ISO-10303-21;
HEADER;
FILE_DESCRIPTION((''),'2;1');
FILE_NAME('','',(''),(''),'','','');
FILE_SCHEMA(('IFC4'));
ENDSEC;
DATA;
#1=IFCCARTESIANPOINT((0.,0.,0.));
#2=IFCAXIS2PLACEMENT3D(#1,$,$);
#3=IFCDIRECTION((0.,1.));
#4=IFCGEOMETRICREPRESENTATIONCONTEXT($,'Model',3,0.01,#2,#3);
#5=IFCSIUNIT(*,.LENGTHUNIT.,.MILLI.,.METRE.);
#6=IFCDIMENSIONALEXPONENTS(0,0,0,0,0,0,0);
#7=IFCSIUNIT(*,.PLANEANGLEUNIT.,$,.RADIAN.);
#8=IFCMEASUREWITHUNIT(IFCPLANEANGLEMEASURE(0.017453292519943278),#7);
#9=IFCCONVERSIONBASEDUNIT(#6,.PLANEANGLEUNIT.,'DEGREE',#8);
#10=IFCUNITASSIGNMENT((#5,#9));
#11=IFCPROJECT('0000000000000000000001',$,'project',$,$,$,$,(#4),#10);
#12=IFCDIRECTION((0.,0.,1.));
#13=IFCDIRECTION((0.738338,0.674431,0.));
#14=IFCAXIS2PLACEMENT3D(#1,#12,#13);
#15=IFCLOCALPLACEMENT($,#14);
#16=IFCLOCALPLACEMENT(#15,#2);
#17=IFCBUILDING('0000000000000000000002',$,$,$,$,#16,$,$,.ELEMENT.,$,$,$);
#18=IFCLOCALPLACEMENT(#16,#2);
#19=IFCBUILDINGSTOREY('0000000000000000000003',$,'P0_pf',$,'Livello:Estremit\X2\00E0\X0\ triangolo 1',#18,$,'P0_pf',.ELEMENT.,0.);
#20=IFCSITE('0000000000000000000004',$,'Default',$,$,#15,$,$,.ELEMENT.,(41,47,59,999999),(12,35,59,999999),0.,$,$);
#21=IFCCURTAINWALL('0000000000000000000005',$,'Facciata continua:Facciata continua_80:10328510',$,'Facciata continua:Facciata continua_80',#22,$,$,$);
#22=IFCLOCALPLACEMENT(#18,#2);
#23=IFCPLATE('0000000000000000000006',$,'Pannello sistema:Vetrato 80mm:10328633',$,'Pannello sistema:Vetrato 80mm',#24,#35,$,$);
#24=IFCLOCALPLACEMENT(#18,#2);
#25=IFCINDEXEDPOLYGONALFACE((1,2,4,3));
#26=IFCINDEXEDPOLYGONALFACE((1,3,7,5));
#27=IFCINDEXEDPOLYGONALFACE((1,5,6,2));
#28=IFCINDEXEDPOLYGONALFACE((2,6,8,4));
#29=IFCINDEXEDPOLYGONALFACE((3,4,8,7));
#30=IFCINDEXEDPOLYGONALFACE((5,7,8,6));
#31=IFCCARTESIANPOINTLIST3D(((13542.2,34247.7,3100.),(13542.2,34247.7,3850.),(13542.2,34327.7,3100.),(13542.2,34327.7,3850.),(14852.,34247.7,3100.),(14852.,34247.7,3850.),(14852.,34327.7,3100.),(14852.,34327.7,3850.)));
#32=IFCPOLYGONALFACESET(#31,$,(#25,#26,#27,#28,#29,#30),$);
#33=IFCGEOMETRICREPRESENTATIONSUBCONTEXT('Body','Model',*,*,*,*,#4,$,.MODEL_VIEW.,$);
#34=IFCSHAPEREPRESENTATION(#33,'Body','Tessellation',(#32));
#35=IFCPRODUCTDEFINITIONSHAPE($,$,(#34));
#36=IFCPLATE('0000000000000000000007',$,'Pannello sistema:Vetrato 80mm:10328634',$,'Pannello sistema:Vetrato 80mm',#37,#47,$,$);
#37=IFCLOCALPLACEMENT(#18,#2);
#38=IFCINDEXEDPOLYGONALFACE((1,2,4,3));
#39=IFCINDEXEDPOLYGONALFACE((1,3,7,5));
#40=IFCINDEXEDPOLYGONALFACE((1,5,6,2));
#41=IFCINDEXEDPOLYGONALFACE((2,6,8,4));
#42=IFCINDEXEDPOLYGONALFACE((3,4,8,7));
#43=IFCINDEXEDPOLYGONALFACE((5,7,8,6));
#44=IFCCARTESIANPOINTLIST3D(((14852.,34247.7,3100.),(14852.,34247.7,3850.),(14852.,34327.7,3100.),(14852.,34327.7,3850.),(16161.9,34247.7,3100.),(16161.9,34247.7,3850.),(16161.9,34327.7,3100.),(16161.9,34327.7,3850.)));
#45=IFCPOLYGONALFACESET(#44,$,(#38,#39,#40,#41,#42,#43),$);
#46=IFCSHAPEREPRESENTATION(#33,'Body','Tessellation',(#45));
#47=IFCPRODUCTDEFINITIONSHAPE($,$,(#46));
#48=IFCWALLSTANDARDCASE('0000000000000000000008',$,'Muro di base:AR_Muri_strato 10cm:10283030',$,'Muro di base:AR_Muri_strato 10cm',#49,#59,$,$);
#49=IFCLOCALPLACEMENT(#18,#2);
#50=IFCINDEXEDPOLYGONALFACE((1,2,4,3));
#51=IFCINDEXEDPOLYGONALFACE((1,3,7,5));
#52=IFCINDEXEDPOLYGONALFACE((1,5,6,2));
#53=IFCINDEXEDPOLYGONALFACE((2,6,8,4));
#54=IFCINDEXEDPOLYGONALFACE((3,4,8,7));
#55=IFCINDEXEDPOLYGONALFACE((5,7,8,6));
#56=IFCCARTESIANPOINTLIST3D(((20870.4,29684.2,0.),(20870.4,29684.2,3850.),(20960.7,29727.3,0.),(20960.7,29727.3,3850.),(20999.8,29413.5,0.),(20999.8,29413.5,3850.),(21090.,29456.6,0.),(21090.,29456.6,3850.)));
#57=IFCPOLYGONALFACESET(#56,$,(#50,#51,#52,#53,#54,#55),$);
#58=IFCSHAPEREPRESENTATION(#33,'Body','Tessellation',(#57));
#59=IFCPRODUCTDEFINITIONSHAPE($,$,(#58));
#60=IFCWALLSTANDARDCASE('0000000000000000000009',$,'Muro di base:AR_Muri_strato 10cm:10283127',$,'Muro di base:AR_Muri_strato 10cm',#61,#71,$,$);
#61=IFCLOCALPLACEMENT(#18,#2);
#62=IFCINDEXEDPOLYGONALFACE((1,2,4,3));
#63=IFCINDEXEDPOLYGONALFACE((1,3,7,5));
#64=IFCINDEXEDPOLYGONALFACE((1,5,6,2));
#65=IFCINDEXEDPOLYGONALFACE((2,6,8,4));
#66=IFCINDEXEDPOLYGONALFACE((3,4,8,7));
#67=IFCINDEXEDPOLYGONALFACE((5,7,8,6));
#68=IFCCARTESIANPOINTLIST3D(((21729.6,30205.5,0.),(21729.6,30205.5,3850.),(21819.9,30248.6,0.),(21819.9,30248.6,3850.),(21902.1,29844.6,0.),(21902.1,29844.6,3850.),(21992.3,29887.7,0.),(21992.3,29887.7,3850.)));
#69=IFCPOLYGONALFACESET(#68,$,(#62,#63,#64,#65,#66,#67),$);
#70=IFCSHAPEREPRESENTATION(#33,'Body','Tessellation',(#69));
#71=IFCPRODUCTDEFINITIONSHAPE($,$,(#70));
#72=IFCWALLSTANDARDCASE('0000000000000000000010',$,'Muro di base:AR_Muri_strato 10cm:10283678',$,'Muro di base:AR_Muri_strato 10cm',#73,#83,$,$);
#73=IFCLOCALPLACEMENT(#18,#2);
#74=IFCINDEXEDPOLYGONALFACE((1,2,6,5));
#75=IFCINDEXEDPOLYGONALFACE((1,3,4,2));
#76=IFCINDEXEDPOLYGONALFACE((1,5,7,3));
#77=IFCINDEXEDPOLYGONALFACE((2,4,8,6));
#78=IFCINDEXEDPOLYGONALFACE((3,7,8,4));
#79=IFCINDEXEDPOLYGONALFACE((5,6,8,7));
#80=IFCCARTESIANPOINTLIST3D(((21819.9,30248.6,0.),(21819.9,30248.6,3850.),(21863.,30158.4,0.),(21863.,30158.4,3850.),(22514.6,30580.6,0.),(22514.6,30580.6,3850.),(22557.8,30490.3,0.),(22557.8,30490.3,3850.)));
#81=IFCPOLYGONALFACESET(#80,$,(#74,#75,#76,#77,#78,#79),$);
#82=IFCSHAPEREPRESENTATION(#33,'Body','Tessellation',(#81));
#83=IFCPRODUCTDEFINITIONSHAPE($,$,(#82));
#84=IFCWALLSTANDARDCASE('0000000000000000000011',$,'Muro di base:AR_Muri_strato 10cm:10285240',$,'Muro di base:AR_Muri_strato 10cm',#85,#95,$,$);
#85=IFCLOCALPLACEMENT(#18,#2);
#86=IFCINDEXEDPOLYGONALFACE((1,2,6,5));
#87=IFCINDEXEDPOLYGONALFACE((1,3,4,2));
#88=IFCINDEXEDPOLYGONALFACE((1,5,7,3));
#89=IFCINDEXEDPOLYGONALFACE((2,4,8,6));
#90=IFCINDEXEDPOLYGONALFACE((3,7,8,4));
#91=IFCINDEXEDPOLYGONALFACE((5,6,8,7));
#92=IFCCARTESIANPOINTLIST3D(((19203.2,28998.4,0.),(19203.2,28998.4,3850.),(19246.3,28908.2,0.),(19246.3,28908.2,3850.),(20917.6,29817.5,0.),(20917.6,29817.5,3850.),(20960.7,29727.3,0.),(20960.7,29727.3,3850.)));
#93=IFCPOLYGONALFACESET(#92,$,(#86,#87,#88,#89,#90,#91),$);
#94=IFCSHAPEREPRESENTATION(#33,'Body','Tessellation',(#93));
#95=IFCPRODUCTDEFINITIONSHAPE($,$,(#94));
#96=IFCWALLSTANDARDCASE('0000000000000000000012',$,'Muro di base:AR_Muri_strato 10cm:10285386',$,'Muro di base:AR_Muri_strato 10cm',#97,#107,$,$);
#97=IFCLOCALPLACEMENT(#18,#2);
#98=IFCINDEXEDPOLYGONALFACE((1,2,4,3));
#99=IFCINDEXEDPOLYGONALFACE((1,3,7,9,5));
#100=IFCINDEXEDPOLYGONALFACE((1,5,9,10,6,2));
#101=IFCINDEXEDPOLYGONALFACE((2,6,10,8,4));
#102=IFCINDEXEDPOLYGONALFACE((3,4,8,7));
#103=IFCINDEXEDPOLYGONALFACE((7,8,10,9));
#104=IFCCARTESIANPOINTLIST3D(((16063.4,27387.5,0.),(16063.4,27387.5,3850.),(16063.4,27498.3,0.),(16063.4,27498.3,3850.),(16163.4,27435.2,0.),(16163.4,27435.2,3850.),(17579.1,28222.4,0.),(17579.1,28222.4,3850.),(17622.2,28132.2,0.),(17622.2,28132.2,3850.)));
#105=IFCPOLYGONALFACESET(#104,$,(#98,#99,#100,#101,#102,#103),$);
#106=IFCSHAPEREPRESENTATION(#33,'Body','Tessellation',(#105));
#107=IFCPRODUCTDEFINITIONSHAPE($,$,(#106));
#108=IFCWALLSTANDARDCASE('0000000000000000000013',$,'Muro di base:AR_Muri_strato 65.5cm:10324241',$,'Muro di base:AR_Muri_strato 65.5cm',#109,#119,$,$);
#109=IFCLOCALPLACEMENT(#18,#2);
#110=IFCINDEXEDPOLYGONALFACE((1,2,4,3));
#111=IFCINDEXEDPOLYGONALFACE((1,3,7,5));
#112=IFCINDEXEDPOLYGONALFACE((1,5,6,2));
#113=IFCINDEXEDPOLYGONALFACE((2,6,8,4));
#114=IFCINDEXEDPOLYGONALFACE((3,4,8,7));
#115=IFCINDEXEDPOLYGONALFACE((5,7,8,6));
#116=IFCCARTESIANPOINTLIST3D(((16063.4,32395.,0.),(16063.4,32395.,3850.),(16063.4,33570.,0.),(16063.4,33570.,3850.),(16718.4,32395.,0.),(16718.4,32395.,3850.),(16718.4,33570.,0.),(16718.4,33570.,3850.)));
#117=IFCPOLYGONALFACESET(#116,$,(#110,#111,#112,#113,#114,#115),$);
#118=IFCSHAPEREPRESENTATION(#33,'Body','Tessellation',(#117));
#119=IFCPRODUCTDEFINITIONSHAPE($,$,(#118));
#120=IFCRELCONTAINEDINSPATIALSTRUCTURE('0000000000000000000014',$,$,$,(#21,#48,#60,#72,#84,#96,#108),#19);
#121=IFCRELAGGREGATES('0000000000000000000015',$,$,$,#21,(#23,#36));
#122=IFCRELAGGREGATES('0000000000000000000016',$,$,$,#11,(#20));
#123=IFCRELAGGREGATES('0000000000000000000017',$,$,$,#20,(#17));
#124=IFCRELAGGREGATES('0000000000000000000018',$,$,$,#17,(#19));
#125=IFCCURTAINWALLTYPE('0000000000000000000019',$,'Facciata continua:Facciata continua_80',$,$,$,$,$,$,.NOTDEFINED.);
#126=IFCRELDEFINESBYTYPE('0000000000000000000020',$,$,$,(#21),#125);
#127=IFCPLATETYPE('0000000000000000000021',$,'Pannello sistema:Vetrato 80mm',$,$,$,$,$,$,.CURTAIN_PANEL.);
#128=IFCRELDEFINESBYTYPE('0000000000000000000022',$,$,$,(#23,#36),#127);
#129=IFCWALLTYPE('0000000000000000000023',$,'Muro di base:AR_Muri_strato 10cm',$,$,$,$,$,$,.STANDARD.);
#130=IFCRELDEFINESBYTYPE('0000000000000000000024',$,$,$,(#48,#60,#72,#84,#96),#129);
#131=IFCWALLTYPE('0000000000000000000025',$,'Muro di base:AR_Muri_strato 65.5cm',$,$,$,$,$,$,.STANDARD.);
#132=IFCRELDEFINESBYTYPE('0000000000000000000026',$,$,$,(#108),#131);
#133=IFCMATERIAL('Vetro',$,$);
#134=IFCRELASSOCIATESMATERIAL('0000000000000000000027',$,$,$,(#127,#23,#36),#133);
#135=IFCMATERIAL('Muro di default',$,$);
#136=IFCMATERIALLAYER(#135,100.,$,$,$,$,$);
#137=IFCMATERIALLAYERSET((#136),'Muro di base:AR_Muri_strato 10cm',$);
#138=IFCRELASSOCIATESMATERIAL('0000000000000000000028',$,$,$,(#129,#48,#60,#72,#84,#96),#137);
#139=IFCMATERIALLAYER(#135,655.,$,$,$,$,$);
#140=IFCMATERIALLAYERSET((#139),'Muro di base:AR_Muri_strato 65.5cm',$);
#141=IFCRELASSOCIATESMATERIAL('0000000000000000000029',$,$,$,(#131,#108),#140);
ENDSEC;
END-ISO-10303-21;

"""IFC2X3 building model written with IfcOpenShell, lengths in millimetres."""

from ifc_helpers import new_model, entity, si_unit, converted_unit, direction, frame, frame_2d, origin, origin_2d_with_axis, place, context, subcontext, project, spatial, polyline, rectangle, outline, extrude, source, transform, mapped, material, layer, layer_set, layer_usage, type_object, type_shapes, element, aggregate, save


model = new_model("IFC2X3")

# Units and contexts
model_context = context("Model", 3, precision=0.01, world=origin(), true_north=direction((0.0, 1.0)))
body_context = subcontext(model_context, "Body", "Model", "MODEL_VIEW")
ifc_project = project(units=[si_unit("LENGTHUNIT", "METRE", prefix="MILLI"), converted_unit("PLANEANGLEUNIT", "DEGREE", entity("IfcPlaneAngleMeasure", 0.017453292519943278), si_unit("PLANEANGLEUNIT", "RADIAN"), dimensions=[0, 0, 0, 0, 0, 0, 0])], contexts=[model_context])

# Site, building, storey
site_placement = place(None, frame((0.0, 0.0, 0.0), z_axis=(0.0, 0.0, 1.0), x_axis=(0.738338, 0.674431, 0.0)))
site = spatial("IfcSite", under=ifc_project, at=site_placement, Name="Default", CompositionType="ELEMENT", RefLatitude=(41, 47, 59, 999999), RefLongitude=(12, 35, 59, 999999), RefElevation=0.0)
building_placement = place(site_placement, origin())
building = spatial("IfcBuilding", under=site, at=building_placement, CompositionType="ELEMENT")
storey_placement = place(building_placement, origin())
storey = spatial("IfcBuildingStorey", under=building, at=storey_placement, Name="P0_pf", ObjectType="Livello:Estremità triangolo 1", LongName="P0_pf", CompositionType="ELEMENT", Elevation=0.0)

# Curtain wall, plates
curtain_wall_type = type_object("IfcCurtainWallType", Name="Facciata continua:Facciata continua_80", PredefinedType="NOTDEFINED")
ifc_material_1 = material(Name="Vetro")
curtain_wall_1_placement = place(storey_placement, origin())
curtain_wall_1 = element("IfcCurtainWall", 1, at=curtain_wall_1_placement, inside=storey, type_object=curtain_wall_type, Name="Facciata continua:Facciata continua_80:10328510", ObjectType="Facciata continua:Facciata continua_80")
plate_type_1 = type_object("IfcPlateType", Name="Pannello sistema:Vetrato 80mm", PredefinedType="CURTAIN_PANEL", material=ifc_material_1)
shared_shape_1 = source(origin(), body_context, "Body", "SweptSolid", [
    extrude(rectangle(XDim=80.0, YDim=1309.8, at=origin_2d_with_axis()), frame((0.0, -40.0, 0.0), z_axis=(0.0, 0.0, 1.0), x_axis=(0.0, 1.0, 0.0)), (0.0, 0.0, 1.0), 750.0),
])
type_shapes(plate_type_1, [shared_shape_1])
plate_1_placement = place(curtain_wall_1_placement, frame((14197.1, 34327.7, 3100.0)))
plate_1 = element("IfcPlate", 2, at=plate_1_placement, type_object=plate_type_1, material=ifc_material_1, Name="Pannello sistema:Vetrato 80mm:10328633", ObjectType="Pannello sistema:Vetrato 80mm", context=body_context, shape_type="MappedRepresentation", body=[
    mapped(shared_shape_1, transform((0.0, 0.0, 0.0), scale=1.0)),
])
plate_2_placement = place(curtain_wall_1_placement, frame((15506.9, 34327.7, 3100.0)))
plate_2 = element("IfcPlate", 3, at=plate_2_placement, type_object=plate_type_1, material=ifc_material_1, Name="Pannello sistema:Vetrato 80mm:10328634", ObjectType="Pannello sistema:Vetrato 80mm", context=body_context, shape_type="MappedRepresentation", body=[
    mapped(shared_shape_1, transform((0.0, 0.0, 0.0), scale=1.0)),
])
aggregate(curtain_wall_1, [plate_1, plate_2])

# Walls
ifc_material_2 = material(Name="Muro di default")
ifc_layer_1 = layer(ifc_material_2, 100.0)
ifc_layer_set_1 = layer_set([ifc_layer_1], Name="Muro di base:AR_Muri_strato 10cm")
ifc_layer_usage_1 = layer_usage(ifc_layer_set_1, "AXIS2", "NEGATIVE", 50.0)
wall_type_1 = type_object("IfcWallType", Name="Muro di base:AR_Muri_strato 10cm", PredefinedType="STANDARD", material=ifc_layer_set_1)
wall_1_placement = place(storey_placement, frame((21044.9, 29435.0, 0.0), z_axis=(0.0, 0.0, 1.0), x_axis=(-0.431105, 0.902302, 0.0)))
element("IfcWallStandardCase", 4, at=wall_1_placement, inside=storey, type_object=wall_type_1, material=ifc_layer_usage_1, Name="Muro di base:AR_Muri_strato 10cm:10283030", ObjectType="Muro di base:AR_Muri_strato 10cm", context=body_context, shape_type="SweptSolid", body=[
    extrude(rectangle(XDim=300.0, YDim=100.0, at=frame_2d((150.0, 0.0), x_axis=(-1.0, 0.0))), origin(), (0.0, 0.0, 1.0), 3850.0),
])
ifc_layer_usage_2 = layer_usage(ifc_layer_set_1, "AXIS2", "NEGATIVE", 50.0)
wall_2_placement = place(storey_placement, frame((21774.7, 30227.1, 0.0), z_axis=(0.0, 0.0, 1.0), x_axis=(0.431105, -0.902302, 0.0)))
element("IfcWallStandardCase", 5, at=wall_2_placement, inside=storey, type_object=wall_type_1, material=ifc_layer_usage_2, Name="Muro di base:AR_Muri_strato 10cm:10283127", ObjectType="Muro di base:AR_Muri_strato 10cm", context=body_context, shape_type="SweptSolid", body=[
    extrude(rectangle(XDim=400.0, YDim=100.0, at=frame_2d((200.0, 0.0), x_axis=(-1.0, 0.0))), origin(), (0.0, 0.0, 1.0), 3850.0),
])
ifc_layer_usage_3 = layer_usage(ifc_layer_set_1, "AXIS2", "NEGATIVE", 50.0)
wall_3_placement = place(storey_placement, frame((22536.2, 30535.5, 0.0), z_axis=(0.0, 0.0, 1.0), x_axis=(-0.902302, -0.431105, 0.0)))
element("IfcWallStandardCase", 6, at=wall_3_placement, inside=storey, type_object=wall_type_1, material=ifc_layer_usage_3, Name="Muro di base:AR_Muri_strato 10cm:10283678", ObjectType="Muro di base:AR_Muri_strato 10cm", context=body_context, shape_type="SweptSolid", body=[
    extrude(rectangle(XDim=770.0, YDim=100.0, at=frame_2d((385.0, 0.0), x_axis=(-1.0, 0.0))), origin(), (0.0, 0.0, 1.0), 3850.0),
])
ifc_layer_usage_4 = layer_usage(ifc_layer_set_1, "AXIS2", "NEGATIVE", 50.0)
wall_4_placement = place(storey_placement, frame((20939.1, 29772.4, 0.0), z_axis=(0.0, 0.0, 1.0), x_axis=(-0.902302, -0.431105, 0.0)))
element("IfcWallStandardCase", 7, at=wall_4_placement, inside=storey, type_object=wall_type_1, material=ifc_layer_usage_4, Name="Muro di base:AR_Muri_strato 10cm:10285240", ObjectType="Muro di base:AR_Muri_strato 10cm", context=body_context, shape_type="SweptSolid", body=[
    extrude(rectangle(XDim=1900.0, YDim=100.0, at=frame_2d((950.0, 0.0), x_axis=(-1.0, 0.0))), origin(), (0.0, 0.0, 1.0), 3850.0),
])
ifc_layer_usage_5 = layer_usage(ifc_layer_set_1, "AXIS2", "NEGATIVE", 50.0)
wall_5_placement = place(storey_placement, frame((17600.6, 28177.3, 0.0), z_axis=(0.0, 0.0, 1.0), x_axis=(-0.902302, -0.431105, 0.0)))
element("IfcWallStandardCase", 8, at=wall_5_placement, inside=storey, type_object=wall_type_1, material=ifc_layer_usage_5, Name="Muro di base:AR_Muri_strato 10cm:10285386", ObjectType="Muro di base:AR_Muri_strato 10cm", context=body_context, shape_type="SweptSolid", body=[
    extrude(outline(polyline([(1679.7, -50.0), (1727.5, 50.0), (1616.7, 50.0), (0.0, 50.0), (0.0, -50.0), (1679.7, -50.0)])), origin(), (0.0, 0.0, 1.0), 3850.0),
])
ifc_layer_2 = layer(ifc_material_2, 655.0)
ifc_layer_set_2 = layer_set([ifc_layer_2], Name="Muro di base:AR_Muri_strato 65.5cm")
ifc_layer_usage_6 = layer_usage(ifc_layer_set_2, "AXIS2", "NEGATIVE", 327.5)
wall_type_2 = type_object("IfcWallType", Name="Muro di base:AR_Muri_strato 65.5cm", PredefinedType="STANDARD", material=ifc_layer_set_2)
wall_6_placement = place(storey_placement, frame((16390.9, 32395.0, 0.0), z_axis=(0.0, 0.0, 1.0), x_axis=(0.0, 1.0, 0.0)))
element("IfcWallStandardCase", 9, at=wall_6_placement, inside=storey, type_object=wall_type_2, material=ifc_layer_usage_6, Name="Muro di base:AR_Muri_strato 65.5cm:10324241", ObjectType="Muro di base:AR_Muri_strato 65.5cm", context=body_context, shape_type="SweptSolid", body=[
    extrude(rectangle(XDim=1175.0, YDim=655.0, at=frame_2d((587.5, 0.0), x_axis=(-1.0, 0.0))), origin(), (0.0, 0.0, 1.0), 3850.0),
])

save(model, "model.ifc")
